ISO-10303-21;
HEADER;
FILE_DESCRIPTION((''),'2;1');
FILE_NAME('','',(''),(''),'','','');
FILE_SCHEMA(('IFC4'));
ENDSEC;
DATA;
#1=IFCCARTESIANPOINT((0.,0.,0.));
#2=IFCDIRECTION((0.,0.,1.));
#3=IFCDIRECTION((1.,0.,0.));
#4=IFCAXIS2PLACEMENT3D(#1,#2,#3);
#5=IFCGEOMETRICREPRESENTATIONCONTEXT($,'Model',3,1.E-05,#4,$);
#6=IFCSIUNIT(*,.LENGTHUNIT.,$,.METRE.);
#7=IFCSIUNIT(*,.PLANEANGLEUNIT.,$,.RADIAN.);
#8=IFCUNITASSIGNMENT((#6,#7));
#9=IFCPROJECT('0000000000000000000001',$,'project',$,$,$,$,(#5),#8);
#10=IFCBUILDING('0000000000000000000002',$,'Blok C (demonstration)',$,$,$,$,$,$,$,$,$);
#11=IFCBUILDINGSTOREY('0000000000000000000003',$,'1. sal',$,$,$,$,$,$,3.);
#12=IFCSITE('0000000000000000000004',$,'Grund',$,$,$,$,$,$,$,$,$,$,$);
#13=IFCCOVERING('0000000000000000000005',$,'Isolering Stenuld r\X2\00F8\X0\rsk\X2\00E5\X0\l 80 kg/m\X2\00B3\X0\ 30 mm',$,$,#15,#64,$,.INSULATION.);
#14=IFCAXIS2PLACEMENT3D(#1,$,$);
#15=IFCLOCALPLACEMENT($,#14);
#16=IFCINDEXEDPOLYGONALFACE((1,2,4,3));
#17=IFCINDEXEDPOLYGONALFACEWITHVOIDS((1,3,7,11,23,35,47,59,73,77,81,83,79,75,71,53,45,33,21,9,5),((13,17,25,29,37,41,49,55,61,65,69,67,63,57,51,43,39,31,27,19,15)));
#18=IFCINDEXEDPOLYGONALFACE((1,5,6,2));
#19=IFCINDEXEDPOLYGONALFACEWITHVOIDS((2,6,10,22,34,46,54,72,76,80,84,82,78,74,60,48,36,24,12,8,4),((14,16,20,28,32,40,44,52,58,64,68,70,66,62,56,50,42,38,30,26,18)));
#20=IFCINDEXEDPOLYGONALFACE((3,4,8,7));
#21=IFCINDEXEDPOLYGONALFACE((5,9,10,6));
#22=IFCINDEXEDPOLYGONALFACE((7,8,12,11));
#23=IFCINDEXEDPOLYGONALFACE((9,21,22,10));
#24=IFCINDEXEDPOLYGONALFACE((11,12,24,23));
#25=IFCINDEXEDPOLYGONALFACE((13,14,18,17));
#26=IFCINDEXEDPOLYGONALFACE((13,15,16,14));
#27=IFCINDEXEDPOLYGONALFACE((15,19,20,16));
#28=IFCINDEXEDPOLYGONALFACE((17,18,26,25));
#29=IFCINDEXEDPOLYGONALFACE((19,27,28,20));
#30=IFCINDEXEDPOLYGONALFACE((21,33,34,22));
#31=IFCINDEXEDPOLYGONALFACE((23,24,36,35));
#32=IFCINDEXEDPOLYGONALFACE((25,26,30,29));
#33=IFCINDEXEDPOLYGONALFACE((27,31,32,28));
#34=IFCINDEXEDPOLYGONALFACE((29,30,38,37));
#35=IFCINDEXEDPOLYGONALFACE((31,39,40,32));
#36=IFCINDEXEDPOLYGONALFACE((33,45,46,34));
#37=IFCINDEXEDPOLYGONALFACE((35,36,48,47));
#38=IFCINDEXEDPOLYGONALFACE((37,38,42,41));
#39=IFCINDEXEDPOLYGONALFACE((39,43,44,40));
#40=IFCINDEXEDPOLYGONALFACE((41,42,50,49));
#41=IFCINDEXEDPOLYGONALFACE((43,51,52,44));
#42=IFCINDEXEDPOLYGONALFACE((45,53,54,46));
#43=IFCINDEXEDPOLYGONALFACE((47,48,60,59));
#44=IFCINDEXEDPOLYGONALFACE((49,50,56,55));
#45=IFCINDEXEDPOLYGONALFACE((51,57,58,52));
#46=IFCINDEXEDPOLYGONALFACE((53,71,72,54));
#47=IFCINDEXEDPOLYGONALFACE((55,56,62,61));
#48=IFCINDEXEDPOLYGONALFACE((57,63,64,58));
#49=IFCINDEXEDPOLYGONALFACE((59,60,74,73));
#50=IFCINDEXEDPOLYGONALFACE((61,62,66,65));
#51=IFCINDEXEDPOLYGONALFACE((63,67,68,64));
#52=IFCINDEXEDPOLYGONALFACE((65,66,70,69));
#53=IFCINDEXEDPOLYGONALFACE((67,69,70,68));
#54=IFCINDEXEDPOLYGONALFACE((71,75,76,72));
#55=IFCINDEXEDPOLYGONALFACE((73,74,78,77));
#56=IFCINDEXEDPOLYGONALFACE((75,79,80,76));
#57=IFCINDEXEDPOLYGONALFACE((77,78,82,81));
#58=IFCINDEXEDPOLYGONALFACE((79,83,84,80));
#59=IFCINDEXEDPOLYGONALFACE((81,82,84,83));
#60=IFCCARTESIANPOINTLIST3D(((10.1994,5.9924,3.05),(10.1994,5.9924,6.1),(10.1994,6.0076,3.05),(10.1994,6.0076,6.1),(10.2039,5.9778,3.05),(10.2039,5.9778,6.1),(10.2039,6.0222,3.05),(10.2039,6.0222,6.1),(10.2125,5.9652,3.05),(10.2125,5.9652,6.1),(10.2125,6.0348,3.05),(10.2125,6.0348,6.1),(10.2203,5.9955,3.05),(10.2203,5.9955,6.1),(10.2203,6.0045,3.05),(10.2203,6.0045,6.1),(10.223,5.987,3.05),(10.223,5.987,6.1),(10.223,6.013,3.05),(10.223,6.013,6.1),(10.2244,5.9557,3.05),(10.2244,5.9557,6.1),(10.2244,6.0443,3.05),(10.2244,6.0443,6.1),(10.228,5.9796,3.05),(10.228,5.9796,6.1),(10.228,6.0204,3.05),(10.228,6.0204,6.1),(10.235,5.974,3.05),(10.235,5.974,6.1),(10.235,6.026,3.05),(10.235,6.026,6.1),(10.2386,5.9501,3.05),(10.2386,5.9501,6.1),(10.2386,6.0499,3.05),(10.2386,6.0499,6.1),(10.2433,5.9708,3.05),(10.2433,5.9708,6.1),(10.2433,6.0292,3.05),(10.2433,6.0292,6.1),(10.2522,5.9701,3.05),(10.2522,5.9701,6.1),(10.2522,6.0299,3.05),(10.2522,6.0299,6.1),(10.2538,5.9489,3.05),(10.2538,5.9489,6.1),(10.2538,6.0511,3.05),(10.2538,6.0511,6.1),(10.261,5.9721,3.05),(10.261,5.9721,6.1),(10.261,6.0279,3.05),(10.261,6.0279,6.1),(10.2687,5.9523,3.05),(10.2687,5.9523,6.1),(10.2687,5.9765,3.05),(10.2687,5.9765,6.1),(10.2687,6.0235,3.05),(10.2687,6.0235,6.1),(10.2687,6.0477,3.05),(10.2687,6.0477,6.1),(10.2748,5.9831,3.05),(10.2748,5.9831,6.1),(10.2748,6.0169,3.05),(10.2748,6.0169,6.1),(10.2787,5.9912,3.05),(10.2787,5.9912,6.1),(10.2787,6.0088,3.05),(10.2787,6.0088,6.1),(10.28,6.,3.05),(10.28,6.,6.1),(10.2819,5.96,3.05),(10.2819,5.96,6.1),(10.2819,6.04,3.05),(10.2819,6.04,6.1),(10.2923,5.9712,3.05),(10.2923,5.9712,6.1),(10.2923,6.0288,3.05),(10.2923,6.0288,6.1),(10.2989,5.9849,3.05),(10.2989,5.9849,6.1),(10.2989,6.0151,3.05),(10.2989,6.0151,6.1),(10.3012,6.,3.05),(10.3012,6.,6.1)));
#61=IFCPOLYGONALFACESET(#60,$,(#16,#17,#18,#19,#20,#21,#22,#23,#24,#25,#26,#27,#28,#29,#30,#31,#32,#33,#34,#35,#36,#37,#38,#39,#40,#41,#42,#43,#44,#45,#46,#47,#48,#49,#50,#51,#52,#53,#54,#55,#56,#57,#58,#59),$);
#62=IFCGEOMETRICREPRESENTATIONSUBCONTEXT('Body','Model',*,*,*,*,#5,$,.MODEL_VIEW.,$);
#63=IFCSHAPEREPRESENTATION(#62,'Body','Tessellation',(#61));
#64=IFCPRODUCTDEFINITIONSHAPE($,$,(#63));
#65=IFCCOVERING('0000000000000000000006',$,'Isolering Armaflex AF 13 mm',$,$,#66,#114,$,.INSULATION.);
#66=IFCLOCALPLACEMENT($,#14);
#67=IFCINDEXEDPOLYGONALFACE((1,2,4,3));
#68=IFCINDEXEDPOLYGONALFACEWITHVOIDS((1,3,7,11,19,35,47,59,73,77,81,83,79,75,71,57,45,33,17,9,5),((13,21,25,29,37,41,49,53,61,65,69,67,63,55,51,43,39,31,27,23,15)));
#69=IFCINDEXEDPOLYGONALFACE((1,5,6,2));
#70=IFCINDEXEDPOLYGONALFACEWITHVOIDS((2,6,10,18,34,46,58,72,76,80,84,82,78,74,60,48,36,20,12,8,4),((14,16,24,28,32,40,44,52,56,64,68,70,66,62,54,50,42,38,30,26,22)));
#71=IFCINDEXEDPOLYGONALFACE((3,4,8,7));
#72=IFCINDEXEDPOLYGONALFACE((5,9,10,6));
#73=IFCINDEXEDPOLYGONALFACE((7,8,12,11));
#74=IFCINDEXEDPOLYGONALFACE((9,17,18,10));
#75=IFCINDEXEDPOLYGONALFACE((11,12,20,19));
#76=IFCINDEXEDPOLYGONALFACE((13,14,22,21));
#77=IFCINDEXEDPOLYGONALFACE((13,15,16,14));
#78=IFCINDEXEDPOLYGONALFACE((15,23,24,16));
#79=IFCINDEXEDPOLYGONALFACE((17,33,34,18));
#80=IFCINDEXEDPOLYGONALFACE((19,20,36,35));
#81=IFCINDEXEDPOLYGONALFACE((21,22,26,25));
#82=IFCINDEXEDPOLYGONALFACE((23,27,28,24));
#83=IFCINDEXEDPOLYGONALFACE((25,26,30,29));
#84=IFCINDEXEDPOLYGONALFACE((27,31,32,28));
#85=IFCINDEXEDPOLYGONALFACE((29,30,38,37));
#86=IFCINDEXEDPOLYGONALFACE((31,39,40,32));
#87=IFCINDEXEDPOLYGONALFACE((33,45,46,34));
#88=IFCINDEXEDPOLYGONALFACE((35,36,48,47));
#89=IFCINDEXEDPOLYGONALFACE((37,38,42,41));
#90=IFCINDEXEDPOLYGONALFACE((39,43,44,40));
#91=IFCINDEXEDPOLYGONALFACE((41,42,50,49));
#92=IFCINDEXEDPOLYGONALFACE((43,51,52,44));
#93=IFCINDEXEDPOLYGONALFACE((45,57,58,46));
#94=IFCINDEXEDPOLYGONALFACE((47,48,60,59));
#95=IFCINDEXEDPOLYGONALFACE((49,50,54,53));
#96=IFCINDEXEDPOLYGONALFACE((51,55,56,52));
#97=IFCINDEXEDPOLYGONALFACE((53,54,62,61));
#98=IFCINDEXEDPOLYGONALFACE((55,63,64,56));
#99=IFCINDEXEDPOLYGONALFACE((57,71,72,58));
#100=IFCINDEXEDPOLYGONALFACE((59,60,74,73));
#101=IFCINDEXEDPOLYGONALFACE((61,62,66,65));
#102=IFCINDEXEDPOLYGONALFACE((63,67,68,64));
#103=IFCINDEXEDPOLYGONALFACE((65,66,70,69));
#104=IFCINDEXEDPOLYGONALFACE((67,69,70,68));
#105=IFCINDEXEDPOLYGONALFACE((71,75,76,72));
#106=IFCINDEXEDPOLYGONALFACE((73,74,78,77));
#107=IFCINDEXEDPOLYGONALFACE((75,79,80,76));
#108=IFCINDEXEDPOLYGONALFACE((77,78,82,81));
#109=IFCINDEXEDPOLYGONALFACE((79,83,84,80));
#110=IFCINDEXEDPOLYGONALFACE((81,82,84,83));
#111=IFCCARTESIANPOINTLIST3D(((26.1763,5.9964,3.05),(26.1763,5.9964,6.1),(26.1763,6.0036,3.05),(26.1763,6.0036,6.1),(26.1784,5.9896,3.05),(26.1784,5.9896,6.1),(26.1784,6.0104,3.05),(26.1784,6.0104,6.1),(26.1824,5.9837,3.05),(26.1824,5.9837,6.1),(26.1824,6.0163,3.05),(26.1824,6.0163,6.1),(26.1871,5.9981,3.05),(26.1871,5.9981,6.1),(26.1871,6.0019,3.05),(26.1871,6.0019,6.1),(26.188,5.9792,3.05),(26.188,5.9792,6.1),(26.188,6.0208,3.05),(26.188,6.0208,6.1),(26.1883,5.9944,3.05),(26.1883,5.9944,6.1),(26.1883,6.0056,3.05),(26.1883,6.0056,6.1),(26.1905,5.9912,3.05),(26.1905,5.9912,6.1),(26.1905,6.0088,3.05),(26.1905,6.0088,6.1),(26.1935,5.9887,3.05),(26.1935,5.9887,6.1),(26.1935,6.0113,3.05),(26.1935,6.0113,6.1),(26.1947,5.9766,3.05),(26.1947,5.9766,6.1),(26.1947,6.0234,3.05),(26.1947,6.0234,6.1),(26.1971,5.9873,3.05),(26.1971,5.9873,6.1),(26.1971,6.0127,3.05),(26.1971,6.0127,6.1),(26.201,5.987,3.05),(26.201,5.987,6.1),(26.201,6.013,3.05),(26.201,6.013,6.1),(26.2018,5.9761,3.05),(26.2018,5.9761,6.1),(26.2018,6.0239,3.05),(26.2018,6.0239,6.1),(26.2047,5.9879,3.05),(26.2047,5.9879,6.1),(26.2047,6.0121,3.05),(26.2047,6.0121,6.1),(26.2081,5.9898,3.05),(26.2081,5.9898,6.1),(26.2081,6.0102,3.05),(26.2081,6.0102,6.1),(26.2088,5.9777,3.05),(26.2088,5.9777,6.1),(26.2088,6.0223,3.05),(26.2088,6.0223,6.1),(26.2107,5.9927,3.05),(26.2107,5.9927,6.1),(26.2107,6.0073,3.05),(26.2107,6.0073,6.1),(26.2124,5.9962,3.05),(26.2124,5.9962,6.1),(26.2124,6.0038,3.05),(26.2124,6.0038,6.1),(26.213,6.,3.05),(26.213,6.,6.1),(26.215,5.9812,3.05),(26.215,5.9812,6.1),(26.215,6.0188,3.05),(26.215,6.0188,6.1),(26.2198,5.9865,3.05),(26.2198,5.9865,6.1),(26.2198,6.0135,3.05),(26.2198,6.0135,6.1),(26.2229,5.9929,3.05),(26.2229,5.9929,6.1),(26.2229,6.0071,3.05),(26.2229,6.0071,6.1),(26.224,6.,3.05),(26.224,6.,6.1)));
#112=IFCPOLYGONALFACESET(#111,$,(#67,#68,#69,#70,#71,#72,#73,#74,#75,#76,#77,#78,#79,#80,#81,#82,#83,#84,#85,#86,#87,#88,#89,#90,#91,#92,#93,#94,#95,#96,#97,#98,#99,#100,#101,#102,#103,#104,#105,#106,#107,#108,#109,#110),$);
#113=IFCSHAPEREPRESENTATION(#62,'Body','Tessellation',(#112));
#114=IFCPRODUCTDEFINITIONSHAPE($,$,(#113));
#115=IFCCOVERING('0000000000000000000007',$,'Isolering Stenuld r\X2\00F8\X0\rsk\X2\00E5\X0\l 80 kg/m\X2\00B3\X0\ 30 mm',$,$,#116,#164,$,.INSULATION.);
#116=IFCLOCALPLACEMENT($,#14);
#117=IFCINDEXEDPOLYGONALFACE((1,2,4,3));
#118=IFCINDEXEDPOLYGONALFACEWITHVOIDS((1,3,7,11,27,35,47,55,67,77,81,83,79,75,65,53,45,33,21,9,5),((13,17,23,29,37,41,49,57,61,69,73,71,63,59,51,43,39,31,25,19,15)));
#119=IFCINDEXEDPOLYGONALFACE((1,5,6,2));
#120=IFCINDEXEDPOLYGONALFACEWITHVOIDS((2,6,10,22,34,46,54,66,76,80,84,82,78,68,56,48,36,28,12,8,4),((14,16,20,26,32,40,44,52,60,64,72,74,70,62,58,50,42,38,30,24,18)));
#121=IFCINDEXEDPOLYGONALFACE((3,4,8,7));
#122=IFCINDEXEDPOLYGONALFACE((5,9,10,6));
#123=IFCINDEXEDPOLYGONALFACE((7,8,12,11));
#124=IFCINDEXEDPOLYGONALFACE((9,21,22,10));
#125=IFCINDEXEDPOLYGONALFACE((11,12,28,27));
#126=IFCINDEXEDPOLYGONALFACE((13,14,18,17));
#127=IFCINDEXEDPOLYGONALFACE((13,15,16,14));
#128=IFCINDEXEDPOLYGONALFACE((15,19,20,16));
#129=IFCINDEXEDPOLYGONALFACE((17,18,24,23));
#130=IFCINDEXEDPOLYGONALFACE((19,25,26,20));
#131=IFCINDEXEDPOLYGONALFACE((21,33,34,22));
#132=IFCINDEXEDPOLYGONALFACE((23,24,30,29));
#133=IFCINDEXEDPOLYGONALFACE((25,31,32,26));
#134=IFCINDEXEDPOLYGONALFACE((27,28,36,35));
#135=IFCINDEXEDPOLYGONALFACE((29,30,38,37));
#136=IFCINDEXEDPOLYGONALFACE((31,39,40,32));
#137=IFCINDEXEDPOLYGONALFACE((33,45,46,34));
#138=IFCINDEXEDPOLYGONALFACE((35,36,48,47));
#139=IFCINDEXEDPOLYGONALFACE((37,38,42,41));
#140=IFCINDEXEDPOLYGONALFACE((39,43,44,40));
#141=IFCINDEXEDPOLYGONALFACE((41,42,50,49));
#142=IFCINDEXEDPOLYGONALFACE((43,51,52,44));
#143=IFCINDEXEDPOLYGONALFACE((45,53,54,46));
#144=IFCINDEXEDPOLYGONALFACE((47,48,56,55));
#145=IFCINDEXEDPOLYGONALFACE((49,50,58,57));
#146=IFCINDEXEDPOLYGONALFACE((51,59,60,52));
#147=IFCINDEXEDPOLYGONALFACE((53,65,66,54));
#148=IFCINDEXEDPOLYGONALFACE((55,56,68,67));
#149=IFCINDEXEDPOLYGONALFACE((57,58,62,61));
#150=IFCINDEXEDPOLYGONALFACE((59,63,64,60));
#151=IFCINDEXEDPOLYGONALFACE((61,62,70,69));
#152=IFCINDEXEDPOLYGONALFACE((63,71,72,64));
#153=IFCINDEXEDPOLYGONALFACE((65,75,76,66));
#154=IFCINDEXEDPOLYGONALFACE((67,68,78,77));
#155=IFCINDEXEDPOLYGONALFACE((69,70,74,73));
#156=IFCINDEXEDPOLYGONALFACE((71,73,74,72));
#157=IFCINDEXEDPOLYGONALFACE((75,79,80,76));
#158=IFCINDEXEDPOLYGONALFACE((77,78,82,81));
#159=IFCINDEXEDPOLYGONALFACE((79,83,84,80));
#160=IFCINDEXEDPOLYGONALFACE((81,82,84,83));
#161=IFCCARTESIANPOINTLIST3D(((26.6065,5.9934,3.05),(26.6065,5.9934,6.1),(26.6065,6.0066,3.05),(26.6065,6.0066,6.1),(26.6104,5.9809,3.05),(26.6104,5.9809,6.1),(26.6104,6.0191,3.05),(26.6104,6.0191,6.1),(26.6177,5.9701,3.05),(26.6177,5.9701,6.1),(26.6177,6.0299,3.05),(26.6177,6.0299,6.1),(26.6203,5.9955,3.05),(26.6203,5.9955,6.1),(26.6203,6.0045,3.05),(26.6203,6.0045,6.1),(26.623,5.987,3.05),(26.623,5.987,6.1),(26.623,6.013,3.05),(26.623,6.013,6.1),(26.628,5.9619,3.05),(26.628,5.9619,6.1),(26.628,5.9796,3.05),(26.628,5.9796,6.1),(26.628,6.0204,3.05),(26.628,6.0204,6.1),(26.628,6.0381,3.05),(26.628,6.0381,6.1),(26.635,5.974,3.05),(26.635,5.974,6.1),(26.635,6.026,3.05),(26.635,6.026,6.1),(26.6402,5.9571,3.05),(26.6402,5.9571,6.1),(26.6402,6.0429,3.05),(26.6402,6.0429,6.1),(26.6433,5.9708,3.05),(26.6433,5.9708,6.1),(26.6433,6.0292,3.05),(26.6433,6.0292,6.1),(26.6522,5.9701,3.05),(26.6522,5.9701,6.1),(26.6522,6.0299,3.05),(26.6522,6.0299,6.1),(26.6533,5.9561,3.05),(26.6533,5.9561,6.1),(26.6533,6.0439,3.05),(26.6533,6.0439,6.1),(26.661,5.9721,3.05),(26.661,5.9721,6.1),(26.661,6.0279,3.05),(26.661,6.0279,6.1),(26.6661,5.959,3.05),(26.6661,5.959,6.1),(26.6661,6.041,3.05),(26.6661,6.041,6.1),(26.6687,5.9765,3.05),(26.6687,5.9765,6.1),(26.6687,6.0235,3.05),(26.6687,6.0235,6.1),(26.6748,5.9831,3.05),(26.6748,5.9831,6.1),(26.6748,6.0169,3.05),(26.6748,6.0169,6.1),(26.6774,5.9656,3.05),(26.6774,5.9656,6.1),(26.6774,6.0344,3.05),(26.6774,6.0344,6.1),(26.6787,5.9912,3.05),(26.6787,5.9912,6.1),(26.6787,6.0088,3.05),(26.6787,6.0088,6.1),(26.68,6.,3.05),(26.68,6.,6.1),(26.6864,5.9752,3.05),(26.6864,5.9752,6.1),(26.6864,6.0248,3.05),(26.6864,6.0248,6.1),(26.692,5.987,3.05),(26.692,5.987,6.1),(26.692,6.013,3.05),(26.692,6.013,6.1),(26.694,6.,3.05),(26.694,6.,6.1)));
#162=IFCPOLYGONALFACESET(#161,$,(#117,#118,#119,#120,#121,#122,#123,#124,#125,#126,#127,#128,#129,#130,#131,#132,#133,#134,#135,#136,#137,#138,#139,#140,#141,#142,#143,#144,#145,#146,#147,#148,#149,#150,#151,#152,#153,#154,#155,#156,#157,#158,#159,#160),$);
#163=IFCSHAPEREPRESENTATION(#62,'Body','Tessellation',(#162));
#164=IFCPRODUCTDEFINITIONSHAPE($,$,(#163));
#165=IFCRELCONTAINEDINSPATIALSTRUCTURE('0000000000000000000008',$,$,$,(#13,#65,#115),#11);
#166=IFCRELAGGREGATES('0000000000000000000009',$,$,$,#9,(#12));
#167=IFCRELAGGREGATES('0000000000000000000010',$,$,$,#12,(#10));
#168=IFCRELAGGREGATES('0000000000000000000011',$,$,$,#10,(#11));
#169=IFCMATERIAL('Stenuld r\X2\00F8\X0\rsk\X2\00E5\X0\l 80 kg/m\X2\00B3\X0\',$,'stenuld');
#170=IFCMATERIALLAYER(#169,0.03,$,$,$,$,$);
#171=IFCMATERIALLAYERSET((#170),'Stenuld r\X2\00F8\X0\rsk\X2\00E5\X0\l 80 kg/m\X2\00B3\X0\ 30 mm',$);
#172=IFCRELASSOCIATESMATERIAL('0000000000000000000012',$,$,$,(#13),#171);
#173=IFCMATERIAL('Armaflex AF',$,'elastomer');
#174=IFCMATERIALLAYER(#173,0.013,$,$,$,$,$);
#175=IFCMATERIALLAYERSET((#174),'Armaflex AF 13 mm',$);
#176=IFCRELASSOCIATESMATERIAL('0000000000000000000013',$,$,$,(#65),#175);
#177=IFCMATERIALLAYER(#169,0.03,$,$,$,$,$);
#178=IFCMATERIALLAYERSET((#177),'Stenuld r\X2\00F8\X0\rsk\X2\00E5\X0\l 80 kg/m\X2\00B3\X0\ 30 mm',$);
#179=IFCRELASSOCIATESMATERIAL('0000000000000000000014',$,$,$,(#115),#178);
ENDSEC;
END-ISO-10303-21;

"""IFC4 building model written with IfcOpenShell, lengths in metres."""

from ifc_helpers import new_model, si_unit, frame, origin_with_axes, place, context, subcontext, project, spatial, hollow_circle, extrude, material, layer, layer_set, element, save


model = new_model("IFC4")

# Units and contexts
model_context = context("Model", 3, precision=1e-05, world=origin_with_axes())
body_context = subcontext(model_context, "Body", "Model", "MODEL_VIEW")
ifc_project = project(units=[si_unit("LENGTHUNIT", "METRE"), si_unit("PLANEANGLEUNIT", "RADIAN")], contexts=[model_context])

# Site, building, storey
site = spatial("IfcSite", under=ifc_project, Name="Grund")
building = spatial("IfcBuilding", under=site, Name="Blok C (demonstration)")
storey = spatial("IfcBuildingStorey", under=building, Name="1. sal", Elevation=3.0)

# Coverings
ifc_material_1 = material(Name="Stenuld rørskål 80 kg/m³", Category="stenuld")
ifc_layer_1 = layer(ifc_material_1, 0.03)
ifc_layer_set_1 = layer_set([ifc_layer_1], Name="Stenuld rørskål 80 kg/m³ 30 mm")
covering_1_placement = place(None, origin_with_axes())
element("IfcCovering", 1, at=covering_1_placement, inside=storey, material=ifc_layer_set_1, Name="Isolering Stenuld rørskål 80 kg/m³ 30 mm", PredefinedType="INSULATION", context=body_context, shape_type="SweptSolid", body=[
    extrude(hollow_circle(Radius=0.0512, WallThickness=0.0212), frame((10.25, 6.0, 3.05), z_axis=(0.0, 0.0, 1.0), x_axis=(1.0, 0.0, 0.0)), (0.0, 0.0, 1.0), 3.05),
])
ifc_material_2 = material(Name="Armaflex AF", Category="elastomer")
ifc_layer_2 = layer(ifc_material_2, 0.013)
ifc_layer_set_2 = layer_set([ifc_layer_2], Name="Armaflex AF 13 mm")
covering_2_placement = place(None, origin_with_axes())
element("IfcCovering", 2, at=covering_2_placement, inside=storey, material=ifc_layer_set_2, Name="Isolering Armaflex AF 13 mm", PredefinedType="INSULATION", context=body_context, shape_type="SweptSolid", body=[
    extrude(hollow_circle(Radius=0.024, WallThickness=0.011), frame((26.2, 6.0, 3.05), z_axis=(0.0, 0.0, 1.0), x_axis=(1.0, 0.0, 0.0)), (0.0, 0.0, 1.0), 3.05),
])
ifc_layer_3 = layer(ifc_material_1, 0.03)
ifc_layer_set_3 = layer_set([ifc_layer_3], Name="Stenuld rørskål 80 kg/m³ 30 mm")
covering_3_placement = place(None, origin_with_axes())
element("IfcCovering", 3, at=covering_3_placement, inside=storey, material=ifc_layer_set_3, Name="Isolering Stenuld rørskål 80 kg/m³ 30 mm", PredefinedType="INSULATION", context=body_context, shape_type="SweptSolid", body=[
    extrude(hollow_circle(Radius=0.044, WallThickness=0.014), frame((26.65, 6.0, 3.05), z_axis=(0.0, 0.0, 1.0), x_axis=(1.0, 0.0, 0.0)), (0.0, 0.0, 1.0), 3.05),
])

save(model, "model.ifc")
